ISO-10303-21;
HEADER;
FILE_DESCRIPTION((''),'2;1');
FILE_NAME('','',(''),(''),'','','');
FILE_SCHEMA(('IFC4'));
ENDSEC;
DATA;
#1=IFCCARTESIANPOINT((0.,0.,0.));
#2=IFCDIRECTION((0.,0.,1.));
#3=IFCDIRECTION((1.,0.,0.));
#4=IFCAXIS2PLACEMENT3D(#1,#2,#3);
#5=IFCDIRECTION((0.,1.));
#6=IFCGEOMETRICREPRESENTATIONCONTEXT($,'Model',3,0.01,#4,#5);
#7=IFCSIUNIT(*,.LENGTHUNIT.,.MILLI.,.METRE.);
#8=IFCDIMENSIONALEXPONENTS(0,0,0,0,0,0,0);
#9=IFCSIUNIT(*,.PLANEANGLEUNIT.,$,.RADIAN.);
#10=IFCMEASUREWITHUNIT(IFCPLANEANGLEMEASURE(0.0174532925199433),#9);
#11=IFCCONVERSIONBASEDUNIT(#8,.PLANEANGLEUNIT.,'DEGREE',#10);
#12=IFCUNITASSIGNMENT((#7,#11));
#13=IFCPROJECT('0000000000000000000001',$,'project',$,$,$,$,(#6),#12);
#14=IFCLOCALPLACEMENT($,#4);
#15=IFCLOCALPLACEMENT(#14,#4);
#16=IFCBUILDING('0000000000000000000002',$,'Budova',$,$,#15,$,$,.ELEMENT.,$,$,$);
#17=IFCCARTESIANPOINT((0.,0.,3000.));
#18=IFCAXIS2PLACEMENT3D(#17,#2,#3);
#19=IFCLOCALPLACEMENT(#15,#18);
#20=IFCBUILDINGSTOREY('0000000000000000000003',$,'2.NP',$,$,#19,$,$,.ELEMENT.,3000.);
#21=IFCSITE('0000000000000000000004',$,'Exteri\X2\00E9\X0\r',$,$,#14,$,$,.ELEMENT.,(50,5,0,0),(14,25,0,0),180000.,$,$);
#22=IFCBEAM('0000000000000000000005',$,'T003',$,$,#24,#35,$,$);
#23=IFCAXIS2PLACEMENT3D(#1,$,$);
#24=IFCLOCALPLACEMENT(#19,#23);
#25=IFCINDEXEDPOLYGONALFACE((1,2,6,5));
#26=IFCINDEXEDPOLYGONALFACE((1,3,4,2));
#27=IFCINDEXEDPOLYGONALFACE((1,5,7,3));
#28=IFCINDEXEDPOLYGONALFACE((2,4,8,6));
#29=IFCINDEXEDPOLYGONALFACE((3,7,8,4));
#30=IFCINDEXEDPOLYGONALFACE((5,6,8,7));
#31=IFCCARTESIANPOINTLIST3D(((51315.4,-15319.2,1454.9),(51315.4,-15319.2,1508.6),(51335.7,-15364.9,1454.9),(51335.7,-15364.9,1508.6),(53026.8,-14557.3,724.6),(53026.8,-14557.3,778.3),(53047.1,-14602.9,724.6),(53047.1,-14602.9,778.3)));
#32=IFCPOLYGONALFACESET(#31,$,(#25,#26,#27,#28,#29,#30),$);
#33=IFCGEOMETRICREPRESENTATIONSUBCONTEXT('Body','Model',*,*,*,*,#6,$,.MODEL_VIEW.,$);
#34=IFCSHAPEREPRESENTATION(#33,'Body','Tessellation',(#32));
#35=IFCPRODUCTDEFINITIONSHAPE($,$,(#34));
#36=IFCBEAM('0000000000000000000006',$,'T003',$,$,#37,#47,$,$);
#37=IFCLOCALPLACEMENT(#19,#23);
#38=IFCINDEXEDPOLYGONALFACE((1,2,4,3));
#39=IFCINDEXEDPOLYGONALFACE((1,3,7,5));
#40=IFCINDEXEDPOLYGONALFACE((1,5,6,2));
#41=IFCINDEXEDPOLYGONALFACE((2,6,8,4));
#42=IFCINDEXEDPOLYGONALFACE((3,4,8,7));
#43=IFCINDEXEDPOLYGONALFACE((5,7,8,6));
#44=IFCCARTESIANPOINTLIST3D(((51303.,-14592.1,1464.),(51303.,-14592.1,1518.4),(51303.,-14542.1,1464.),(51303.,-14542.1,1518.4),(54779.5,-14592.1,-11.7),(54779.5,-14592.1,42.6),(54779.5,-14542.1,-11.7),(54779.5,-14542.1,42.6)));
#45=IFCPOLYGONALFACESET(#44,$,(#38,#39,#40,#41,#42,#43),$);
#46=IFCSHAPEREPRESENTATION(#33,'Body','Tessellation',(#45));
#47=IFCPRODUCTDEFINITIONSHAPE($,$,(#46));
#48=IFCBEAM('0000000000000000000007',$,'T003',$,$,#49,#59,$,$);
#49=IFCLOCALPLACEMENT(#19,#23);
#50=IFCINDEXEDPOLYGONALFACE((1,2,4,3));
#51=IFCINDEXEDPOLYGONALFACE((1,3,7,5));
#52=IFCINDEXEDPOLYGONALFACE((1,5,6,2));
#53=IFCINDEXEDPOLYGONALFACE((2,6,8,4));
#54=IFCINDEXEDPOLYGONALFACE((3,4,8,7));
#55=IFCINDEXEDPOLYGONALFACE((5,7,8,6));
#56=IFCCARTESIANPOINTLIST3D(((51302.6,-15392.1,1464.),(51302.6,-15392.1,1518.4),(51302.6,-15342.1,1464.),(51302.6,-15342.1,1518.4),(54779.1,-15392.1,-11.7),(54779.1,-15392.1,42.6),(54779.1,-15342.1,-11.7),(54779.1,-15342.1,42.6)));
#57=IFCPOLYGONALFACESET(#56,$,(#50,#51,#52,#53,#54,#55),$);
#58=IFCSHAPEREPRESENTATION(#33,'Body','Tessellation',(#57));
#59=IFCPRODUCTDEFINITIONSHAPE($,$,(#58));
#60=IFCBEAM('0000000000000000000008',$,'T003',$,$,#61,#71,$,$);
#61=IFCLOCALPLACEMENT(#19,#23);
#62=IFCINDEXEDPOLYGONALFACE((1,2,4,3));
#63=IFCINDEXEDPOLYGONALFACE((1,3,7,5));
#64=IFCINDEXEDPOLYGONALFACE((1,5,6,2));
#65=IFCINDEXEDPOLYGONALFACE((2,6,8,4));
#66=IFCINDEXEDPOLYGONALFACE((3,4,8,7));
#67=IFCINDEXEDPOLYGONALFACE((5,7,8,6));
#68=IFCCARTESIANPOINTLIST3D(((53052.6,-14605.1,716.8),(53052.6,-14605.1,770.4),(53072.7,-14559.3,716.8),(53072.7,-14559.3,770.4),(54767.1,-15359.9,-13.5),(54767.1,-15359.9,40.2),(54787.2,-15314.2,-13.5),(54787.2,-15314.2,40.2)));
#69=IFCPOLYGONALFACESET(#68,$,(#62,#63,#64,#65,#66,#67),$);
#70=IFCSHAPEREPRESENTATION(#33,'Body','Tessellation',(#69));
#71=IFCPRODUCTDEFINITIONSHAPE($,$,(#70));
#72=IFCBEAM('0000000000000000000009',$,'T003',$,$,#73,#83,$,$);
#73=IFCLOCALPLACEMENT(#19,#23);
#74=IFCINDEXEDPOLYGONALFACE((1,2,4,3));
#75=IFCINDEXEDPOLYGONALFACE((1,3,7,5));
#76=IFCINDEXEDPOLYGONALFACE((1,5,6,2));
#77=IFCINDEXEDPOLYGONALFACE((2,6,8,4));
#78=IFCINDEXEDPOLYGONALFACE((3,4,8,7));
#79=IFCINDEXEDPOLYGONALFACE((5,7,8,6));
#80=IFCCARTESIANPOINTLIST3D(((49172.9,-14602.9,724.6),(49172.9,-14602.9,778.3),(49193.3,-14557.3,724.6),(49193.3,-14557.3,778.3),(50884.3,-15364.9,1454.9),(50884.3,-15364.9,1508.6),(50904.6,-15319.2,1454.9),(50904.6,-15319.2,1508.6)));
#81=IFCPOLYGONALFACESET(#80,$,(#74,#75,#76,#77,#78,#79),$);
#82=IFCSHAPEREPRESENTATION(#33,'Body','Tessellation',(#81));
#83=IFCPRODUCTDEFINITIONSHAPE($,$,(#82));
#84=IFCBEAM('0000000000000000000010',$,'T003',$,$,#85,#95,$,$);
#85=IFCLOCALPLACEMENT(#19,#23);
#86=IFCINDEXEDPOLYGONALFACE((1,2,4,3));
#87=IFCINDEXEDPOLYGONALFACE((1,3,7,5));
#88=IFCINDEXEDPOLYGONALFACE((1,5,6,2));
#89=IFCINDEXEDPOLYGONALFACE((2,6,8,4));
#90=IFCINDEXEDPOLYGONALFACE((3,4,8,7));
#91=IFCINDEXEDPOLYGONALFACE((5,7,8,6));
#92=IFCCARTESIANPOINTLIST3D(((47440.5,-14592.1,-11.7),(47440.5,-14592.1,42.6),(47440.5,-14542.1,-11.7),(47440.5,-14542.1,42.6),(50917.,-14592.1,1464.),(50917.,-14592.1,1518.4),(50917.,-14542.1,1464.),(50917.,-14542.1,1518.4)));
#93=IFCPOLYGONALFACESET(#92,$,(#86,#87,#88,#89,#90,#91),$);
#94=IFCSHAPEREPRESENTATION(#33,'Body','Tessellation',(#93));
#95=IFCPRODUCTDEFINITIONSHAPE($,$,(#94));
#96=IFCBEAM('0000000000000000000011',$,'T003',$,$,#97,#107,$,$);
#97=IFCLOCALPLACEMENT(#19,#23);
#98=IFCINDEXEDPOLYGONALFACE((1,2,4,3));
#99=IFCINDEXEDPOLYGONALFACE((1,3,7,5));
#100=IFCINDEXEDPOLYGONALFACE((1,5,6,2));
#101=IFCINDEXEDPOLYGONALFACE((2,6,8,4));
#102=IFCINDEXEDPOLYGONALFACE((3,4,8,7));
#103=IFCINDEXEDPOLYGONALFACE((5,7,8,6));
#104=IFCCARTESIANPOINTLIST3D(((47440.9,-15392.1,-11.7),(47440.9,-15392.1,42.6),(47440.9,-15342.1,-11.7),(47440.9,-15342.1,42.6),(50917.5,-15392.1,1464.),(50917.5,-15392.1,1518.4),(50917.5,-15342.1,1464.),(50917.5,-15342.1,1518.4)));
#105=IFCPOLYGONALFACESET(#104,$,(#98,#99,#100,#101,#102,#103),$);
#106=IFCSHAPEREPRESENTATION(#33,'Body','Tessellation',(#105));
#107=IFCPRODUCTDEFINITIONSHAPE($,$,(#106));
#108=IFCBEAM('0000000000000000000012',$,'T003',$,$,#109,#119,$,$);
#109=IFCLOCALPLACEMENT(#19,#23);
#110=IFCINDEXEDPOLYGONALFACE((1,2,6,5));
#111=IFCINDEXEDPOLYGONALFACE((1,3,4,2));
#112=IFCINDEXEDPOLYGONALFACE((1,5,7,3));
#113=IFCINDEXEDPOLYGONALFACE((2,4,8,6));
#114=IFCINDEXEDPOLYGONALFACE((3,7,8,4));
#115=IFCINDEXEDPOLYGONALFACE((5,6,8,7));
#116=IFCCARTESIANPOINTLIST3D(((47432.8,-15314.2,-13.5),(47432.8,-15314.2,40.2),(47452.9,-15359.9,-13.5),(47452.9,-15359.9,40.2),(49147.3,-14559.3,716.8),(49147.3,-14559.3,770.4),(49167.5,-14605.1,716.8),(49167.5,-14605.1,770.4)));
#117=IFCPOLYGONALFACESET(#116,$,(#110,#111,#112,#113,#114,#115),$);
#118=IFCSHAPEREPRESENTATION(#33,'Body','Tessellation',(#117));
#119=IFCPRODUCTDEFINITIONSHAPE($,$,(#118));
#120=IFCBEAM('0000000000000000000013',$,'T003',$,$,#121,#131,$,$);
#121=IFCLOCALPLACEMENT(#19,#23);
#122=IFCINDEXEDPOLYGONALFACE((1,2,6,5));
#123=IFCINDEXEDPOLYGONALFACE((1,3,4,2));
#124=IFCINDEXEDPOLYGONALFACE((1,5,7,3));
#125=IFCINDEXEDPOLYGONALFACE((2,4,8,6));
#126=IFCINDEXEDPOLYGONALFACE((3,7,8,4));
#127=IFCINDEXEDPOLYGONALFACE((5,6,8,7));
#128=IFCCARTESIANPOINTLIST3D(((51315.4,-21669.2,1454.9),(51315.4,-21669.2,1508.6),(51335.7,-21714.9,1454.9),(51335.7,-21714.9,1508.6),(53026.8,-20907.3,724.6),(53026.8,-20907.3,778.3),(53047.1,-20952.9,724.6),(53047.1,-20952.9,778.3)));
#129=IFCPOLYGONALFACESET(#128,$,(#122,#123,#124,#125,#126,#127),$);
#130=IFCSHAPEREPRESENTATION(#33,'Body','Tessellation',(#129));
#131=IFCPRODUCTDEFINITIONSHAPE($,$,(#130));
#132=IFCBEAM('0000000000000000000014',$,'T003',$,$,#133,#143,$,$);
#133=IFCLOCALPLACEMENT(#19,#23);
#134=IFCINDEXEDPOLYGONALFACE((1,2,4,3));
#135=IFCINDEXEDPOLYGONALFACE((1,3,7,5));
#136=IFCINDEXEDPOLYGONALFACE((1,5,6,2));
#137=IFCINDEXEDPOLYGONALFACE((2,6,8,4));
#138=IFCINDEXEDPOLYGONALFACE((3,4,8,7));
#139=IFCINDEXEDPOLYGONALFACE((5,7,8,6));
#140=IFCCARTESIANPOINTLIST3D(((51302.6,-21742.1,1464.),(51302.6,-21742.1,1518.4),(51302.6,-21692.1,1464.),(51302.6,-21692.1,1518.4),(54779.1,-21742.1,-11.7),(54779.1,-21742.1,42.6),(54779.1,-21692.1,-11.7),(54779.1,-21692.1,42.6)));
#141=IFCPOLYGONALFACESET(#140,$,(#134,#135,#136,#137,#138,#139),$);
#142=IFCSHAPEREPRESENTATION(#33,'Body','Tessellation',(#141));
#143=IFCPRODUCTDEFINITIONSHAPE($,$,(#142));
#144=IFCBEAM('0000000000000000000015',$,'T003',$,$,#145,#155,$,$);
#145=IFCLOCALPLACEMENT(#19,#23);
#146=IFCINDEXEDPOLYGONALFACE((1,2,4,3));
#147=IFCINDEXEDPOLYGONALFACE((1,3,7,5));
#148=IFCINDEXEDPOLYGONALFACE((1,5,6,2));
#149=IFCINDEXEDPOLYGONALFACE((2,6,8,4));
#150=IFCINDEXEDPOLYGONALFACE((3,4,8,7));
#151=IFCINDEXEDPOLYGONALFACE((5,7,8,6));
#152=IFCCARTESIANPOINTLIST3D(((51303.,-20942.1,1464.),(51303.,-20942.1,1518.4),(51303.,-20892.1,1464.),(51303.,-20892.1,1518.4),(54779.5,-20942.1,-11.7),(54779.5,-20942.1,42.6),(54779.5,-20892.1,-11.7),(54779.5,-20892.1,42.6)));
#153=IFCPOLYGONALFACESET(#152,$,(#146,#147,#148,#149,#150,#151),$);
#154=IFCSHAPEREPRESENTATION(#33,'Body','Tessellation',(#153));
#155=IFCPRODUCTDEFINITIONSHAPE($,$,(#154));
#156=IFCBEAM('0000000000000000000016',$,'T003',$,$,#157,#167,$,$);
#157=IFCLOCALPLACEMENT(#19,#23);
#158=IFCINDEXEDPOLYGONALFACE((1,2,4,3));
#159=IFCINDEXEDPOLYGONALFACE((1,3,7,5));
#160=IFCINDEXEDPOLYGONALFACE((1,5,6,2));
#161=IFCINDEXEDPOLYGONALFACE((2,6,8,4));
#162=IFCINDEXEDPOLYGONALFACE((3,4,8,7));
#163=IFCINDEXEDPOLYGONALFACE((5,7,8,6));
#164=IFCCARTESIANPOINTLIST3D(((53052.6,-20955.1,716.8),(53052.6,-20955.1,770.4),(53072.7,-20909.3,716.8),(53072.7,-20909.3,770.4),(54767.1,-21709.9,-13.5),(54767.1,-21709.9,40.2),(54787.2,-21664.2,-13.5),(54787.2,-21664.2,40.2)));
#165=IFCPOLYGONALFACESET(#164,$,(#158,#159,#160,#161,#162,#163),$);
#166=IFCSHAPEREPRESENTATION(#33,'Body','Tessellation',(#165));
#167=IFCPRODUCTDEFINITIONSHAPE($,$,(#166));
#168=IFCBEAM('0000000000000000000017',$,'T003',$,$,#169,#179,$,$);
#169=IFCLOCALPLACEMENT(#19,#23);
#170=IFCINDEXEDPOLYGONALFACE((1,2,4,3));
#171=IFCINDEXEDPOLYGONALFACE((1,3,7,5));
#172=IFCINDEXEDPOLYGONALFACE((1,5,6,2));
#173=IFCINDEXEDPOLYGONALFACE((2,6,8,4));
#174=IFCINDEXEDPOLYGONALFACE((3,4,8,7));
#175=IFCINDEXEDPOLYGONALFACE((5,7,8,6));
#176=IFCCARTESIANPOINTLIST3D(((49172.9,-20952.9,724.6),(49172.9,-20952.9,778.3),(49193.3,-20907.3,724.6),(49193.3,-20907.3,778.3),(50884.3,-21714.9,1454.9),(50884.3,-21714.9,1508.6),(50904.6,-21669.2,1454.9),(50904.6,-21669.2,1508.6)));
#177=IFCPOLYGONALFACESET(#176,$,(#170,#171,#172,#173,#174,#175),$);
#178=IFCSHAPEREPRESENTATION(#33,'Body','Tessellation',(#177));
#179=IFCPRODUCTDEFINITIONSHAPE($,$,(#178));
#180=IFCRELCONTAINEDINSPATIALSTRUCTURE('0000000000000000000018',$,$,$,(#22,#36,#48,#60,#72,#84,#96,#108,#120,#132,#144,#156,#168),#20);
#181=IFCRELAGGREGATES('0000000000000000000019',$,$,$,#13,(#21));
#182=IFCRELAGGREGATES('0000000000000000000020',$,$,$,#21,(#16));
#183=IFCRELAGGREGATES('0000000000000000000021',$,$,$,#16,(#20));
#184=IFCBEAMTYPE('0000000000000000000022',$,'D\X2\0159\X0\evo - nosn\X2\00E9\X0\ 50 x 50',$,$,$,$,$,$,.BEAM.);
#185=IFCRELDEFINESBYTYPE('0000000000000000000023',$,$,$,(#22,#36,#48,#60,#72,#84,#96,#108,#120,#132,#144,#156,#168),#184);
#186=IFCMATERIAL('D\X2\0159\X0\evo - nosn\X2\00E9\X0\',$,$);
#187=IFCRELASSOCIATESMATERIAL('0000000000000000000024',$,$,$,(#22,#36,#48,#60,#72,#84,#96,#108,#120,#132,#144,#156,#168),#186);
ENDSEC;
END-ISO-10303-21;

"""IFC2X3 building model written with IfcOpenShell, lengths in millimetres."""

from ifc_helpers import new_model, entity, si_unit, converted_unit, direction, frame, frame_2d, origin_with_axes, place, context, subcontext, project, spatial, rectangle, extrude, clip, halfspace, material, type_object, element, save


model = new_model("IFC2X3")

# Units and contexts
model_context = context("Model", 3, precision=0.01, world=origin_with_axes(), true_north=direction((0.0, 1.0)))
body_context = subcontext(model_context, "Body", "Model", "MODEL_VIEW")
ifc_project = project(units=[si_unit("LENGTHUNIT", "METRE", prefix="MILLI"), converted_unit("PLANEANGLEUNIT", "DEGREE", entity("IfcPlaneAngleMeasure", 0.0174532925199433), si_unit("PLANEANGLEUNIT", "RADIAN"), dimensions=[0, 0, 0, 0, 0, 0, 0])], contexts=[model_context])

# Site, building, storey
site_placement = place(None, origin_with_axes())
site = spatial("IfcSite", under=ifc_project, at=site_placement, Name="Exteriér", CompositionType="ELEMENT", RefLatitude=(50, 5, 0, 0), RefLongitude=(14, 25, 0, 0), RefElevation=180000.0)
building_placement = place(site_placement, origin_with_axes())
building = spatial("IfcBuilding", under=site, at=building_placement, Name="Budova", CompositionType="ELEMENT")
storey_placement = place(building_placement, frame((0.0, 0.0, 3000.0), z_axis=(0.0, 0.0, 1.0), x_axis=(1.0, 0.0, 0.0)))
storey = spatial("IfcBuildingStorey", under=building, at=storey_placement, Name="2.NP", CompositionType="ELEMENT", Elevation=3000.0)

# Beams
ifc_material_1 = material(Name="Dřevo - nosné")
beam_type = type_object("IfcBeamType", Name="Dřevo - nosné 50 x 50", PredefinedType="BEAM")
beam_1_placement = place(storey_placement, frame((53036.9, -14580.1, 778.3), z_axis=(0.0, 0.0, 1.0), x_axis=(-0.406755, 0.913537, 0.0)))
element("IfcBeam", 1, at=beam_1_placement, inside=storey, type_object=beam_type, material=ifc_material_1, Name="T003", context=body_context, shape_type="Clipping", body=[
    clip(clip(extrude(rectangle(XDim=50.0, YDim=50.0, at=frame_2d((-25.0, 0.0), x_axis=(1.0, 0.0))), frame((0.0, -25.7, -10.0), z_axis=(0.0, 0.931709, 0.363205), x_axis=(0.0, -0.363205, 0.931709)), (0.0, 0.0, 1.0), 2065.8), halfspace(frame((0.0, 0.0, 0.0), z_axis=(0.0, 1.0, 0.0), x_axis=(0.0, 0.0, 1.0)), True)), halfspace(frame((0.0, 1873.3, 0.0), z_axis=(0.0, -1.0, 0.0), x_axis=(0.0, 0.0, -1.0)), True)),
])
for number, where, z_axis, x_axis, name in (
    (2, (54779.5, -14567.1, 42.6), (0.0, 0.0, 1.0), (0.0, 1.0, 0.0), "T003"),
    (3, (54779.1, -15367.1, 42.6), (0.0, 0.0, 1.0), (0.0, 1.0, 0.0), "T003"),
):
    element("IfcBeam", number, at=place(storey_placement, frame(where, z_axis=z_axis, x_axis=x_axis)), inside=storey, type_object=beam_type, material=ifc_material_1, Name=name, context=body_context, shape_type="Clipping", body=[
        clip(clip(extrude(rectangle(XDim=50.0, YDim=50.0, at=frame_2d((-25.0, 0.0), x_axis=(1.0, 0.0))), frame((0.0, -27.6, -11.7), z_axis=(0.0, 0.920505, 0.390731), x_axis=(0.0, -0.390731, 0.920505)), (0.0, 0.0, 1.0), 3836.8), halfspace(frame((0.0, 0.0, 0.0), z_axis=(0.0, 1.0, 0.0), x_axis=(0.0, 0.0, 1.0)), True)), halfspace(frame((0.0, 3476.5, 0.0), z_axis=(0.0, -1.0, 0.0), x_axis=(0.0, 0.0, -1.0)), True)),
    ])
beam_2_placement = place(storey_placement, frame((54777.2, -15337.0, 40.2), z_axis=(0.0, 0.0, 1.0), x_axis=(0.402939, 0.915227, 0.0)))
element("IfcBeam", 4, at=beam_2_placement, inside=storey, type_object=beam_type, material=ifc_material_1, Name="T003", context=body_context, shape_type="Clipping", body=[
    clip(clip(extrude(rectangle(XDim=50.0, YDim=50.0, at=frame_2d((-25.0, 0.0), x_axis=(1.0, 0.0))), frame((0.0, -25.7, -10.0), z_axis=(0.0, 0.931709, 0.363205), x_axis=(0.0, -0.363205, 0.931709)), (0.0, 0.0, 1.0), 2065.8), halfspace(frame((0.0, 0.0, 0.0), z_axis=(0.0, 1.0, 0.0), x_axis=(0.0, 0.0, 1.0)), True)), halfspace(frame((0.0, 1873.3, 0.0), z_axis=(0.0, -1.0, 0.0), x_axis=(0.0, 0.0, -1.0)), True)),
])
beam_3_placement = place(storey_placement, frame((49183.1, -14580.1, 778.3), z_axis=(0.0, 0.0, 1.0), x_axis=(-0.406755, -0.913537, 0.0)))
element("IfcBeam", 5, at=beam_3_placement, inside=storey, type_object=beam_type, material=ifc_material_1, Name="T003", context=body_context, shape_type="Clipping", body=[
    clip(clip(extrude(rectangle(XDim=50.0, YDim=50.0, at=frame_2d((-25.0, 0.0), x_axis=(1.0, 0.0))), frame((0.0, -25.7, -10.0), z_axis=(0.0, 0.931709, 0.363205), x_axis=(0.0, -0.363205, 0.931709)), (0.0, 0.0, 1.0), 2065.8), halfspace(frame((0.0, 0.0, 0.0), z_axis=(0.0, 1.0, 0.0), x_axis=(0.0, 0.0, 1.0)), True)), halfspace(frame((0.0, 1873.3, 0.0), z_axis=(0.0, -1.0, 0.0), x_axis=(0.0, 0.0, -1.0)), True)),
])
for number, where, z_axis, x_axis, name in (
    (6, (47440.5, -14567.1, 42.6), (0.0, 0.0, 1.0), (0.0, -1.0, 0.0), "T003"),
    (7, (47440.9, -15367.1, 42.6), (0.0, 0.0, 1.0), (0.0, -1.0, 0.0), "T003"),
):
    element("IfcBeam", number, at=place(storey_placement, frame(where, z_axis=z_axis, x_axis=x_axis)), inside=storey, type_object=beam_type, material=ifc_material_1, Name=name, context=body_context, shape_type="Clipping", body=[
        clip(clip(extrude(rectangle(XDim=50.0, YDim=50.0, at=frame_2d((-25.0, 0.0), x_axis=(1.0, 0.0))), frame((0.0, -27.6, -11.7), z_axis=(0.0, 0.920505, 0.390731), x_axis=(0.0, -0.390731, 0.920505)), (0.0, 0.0, 1.0), 3836.8), halfspace(frame((0.0, 0.0, 0.0), z_axis=(0.0, 1.0, 0.0), x_axis=(0.0, 0.0, 1.0)), True)), halfspace(frame((0.0, 3476.5, 0.0), z_axis=(0.0, -1.0, 0.0), x_axis=(0.0, 0.0, -1.0)), True)),
    ])
beam_4_placement = place(storey_placement, frame((47442.9, -15337.0, 40.2), z_axis=(0.0, 0.0, 1.0), x_axis=(0.402939, -0.915227, 0.0)))
element("IfcBeam", 8, at=beam_4_placement, inside=storey, type_object=beam_type, material=ifc_material_1, Name="T003", context=body_context, shape_type="Clipping", body=[
    clip(clip(extrude(rectangle(XDim=50.0, YDim=50.0, at=frame_2d((-25.0, 0.0), x_axis=(1.0, 0.0))), frame((0.0, -25.7, -10.0), z_axis=(0.0, 0.931709, 0.363205), x_axis=(0.0, -0.363205, 0.931709)), (0.0, 0.0, 1.0), 2065.8), halfspace(frame((0.0, 0.0, 0.0), z_axis=(0.0, 1.0, 0.0), x_axis=(0.0, 0.0, 1.0)), True)), halfspace(frame((0.0, 1873.3, 0.0), z_axis=(0.0, -1.0, 0.0), x_axis=(0.0, 0.0, -1.0)), True)),
])
beam_5_placement = place(storey_placement, frame((53036.9, -20930.1, 778.3), z_axis=(0.0, 0.0, 1.0), x_axis=(-0.406755, 0.913537, 0.0)))
element("IfcBeam", 9, at=beam_5_placement, inside=storey, type_object=beam_type, material=ifc_material_1, Name="T003", context=body_context, shape_type="Clipping", body=[
    clip(clip(extrude(rectangle(XDim=50.0, YDim=50.0, at=frame_2d((-25.0, 0.0), x_axis=(1.0, 0.0))), frame((0.0, -25.7, -10.0), z_axis=(0.0, 0.931709, 0.363205), x_axis=(0.0, -0.363205, 0.931709)), (0.0, 0.0, 1.0), 2065.8), halfspace(frame((0.0, 0.0, 0.0), z_axis=(0.0, 1.0, 0.0), x_axis=(0.0, 0.0, 1.0)), True)), halfspace(frame((0.0, 1873.3, 0.0), z_axis=(0.0, -1.0, 0.0), x_axis=(0.0, 0.0, -1.0)), True)),
])
for number, where, z_axis, x_axis, name in (
    (10, (54779.1, -21717.1, 42.6), (0.0, 0.0, 1.0), (0.0, 1.0, 0.0), "T003"),
    (11, (54779.5, -20917.1, 42.6), (0.0, 0.0, 1.0), (0.0, 1.0, 0.0), "T003"),
):
    element("IfcBeam", number, at=place(storey_placement, frame(where, z_axis=z_axis, x_axis=x_axis)), inside=storey, type_object=beam_type, material=ifc_material_1, Name=name, context=body_context, shape_type="Clipping", body=[
        clip(clip(extrude(rectangle(XDim=50.0, YDim=50.0, at=frame_2d((-25.0, 0.0), x_axis=(1.0, 0.0))), frame((0.0, -27.6, -11.7), z_axis=(0.0, 0.920505, 0.390731), x_axis=(0.0, -0.390731, 0.920505)), (0.0, 0.0, 1.0), 3836.8), halfspace(frame((0.0, 0.0, 0.0), z_axis=(0.0, 1.0, 0.0), x_axis=(0.0, 0.0, 1.0)), True)), halfspace(frame((0.0, 3476.5, 0.0), z_axis=(0.0, -1.0, 0.0), x_axis=(0.0, 0.0, -1.0)), True)),
    ])
beam_6_placement = place(storey_placement, frame((54777.2, -21687.0, 40.2), z_axis=(0.0, 0.0, 1.0), x_axis=(0.402939, 0.915227, 0.0)))
element("IfcBeam", 12, at=beam_6_placement, inside=storey, type_object=beam_type, material=ifc_material_1, Name="T003", context=body_context, shape_type="Clipping", body=[
    clip(clip(extrude(rectangle(XDim=50.0, YDim=50.0, at=frame_2d((-25.0, 0.0), x_axis=(1.0, 0.0))), frame((0.0, -25.7, -10.0), z_axis=(0.0, 0.931709, 0.363205), x_axis=(0.0, -0.363205, 0.931709)), (0.0, 0.0, 1.0), 2065.8), halfspace(frame((0.0, 0.0, 0.0), z_axis=(0.0, 1.0, 0.0), x_axis=(0.0, 0.0, 1.0)), True)), halfspace(frame((0.0, 1873.3, 0.0), z_axis=(0.0, -1.0, 0.0), x_axis=(0.0, 0.0, -1.0)), True)),
])
beam_7_placement = place(storey_placement, frame((49183.1, -20930.1, 778.3), z_axis=(0.0, 0.0, 1.0), x_axis=(-0.406755, -0.913537, 0.0)))
element("IfcBeam", 13, at=beam_7_placement, inside=storey, type_object=beam_type, material=ifc_material_1, Name="T003", context=body_context, shape_type="Clipping", body=[
    clip(clip(extrude(rectangle(XDim=50.0, YDim=50.0, at=frame_2d((-25.0, 0.0), x_axis=(1.0, 0.0))), frame((0.0, -25.7, -10.0), z_axis=(0.0, 0.931709, 0.363205), x_axis=(0.0, -0.363205, 0.931709)), (0.0, 0.0, 1.0), 2065.8), halfspace(frame((0.0, 0.0, 0.0), z_axis=(0.0, 1.0, 0.0), x_axis=(0.0, 0.0, 1.0)), True)), halfspace(frame((0.0, 1873.3, 0.0), z_axis=(0.0, -1.0, 0.0), x_axis=(0.0, 0.0, -1.0)), True)),
])

save(model, "model.ifc")
